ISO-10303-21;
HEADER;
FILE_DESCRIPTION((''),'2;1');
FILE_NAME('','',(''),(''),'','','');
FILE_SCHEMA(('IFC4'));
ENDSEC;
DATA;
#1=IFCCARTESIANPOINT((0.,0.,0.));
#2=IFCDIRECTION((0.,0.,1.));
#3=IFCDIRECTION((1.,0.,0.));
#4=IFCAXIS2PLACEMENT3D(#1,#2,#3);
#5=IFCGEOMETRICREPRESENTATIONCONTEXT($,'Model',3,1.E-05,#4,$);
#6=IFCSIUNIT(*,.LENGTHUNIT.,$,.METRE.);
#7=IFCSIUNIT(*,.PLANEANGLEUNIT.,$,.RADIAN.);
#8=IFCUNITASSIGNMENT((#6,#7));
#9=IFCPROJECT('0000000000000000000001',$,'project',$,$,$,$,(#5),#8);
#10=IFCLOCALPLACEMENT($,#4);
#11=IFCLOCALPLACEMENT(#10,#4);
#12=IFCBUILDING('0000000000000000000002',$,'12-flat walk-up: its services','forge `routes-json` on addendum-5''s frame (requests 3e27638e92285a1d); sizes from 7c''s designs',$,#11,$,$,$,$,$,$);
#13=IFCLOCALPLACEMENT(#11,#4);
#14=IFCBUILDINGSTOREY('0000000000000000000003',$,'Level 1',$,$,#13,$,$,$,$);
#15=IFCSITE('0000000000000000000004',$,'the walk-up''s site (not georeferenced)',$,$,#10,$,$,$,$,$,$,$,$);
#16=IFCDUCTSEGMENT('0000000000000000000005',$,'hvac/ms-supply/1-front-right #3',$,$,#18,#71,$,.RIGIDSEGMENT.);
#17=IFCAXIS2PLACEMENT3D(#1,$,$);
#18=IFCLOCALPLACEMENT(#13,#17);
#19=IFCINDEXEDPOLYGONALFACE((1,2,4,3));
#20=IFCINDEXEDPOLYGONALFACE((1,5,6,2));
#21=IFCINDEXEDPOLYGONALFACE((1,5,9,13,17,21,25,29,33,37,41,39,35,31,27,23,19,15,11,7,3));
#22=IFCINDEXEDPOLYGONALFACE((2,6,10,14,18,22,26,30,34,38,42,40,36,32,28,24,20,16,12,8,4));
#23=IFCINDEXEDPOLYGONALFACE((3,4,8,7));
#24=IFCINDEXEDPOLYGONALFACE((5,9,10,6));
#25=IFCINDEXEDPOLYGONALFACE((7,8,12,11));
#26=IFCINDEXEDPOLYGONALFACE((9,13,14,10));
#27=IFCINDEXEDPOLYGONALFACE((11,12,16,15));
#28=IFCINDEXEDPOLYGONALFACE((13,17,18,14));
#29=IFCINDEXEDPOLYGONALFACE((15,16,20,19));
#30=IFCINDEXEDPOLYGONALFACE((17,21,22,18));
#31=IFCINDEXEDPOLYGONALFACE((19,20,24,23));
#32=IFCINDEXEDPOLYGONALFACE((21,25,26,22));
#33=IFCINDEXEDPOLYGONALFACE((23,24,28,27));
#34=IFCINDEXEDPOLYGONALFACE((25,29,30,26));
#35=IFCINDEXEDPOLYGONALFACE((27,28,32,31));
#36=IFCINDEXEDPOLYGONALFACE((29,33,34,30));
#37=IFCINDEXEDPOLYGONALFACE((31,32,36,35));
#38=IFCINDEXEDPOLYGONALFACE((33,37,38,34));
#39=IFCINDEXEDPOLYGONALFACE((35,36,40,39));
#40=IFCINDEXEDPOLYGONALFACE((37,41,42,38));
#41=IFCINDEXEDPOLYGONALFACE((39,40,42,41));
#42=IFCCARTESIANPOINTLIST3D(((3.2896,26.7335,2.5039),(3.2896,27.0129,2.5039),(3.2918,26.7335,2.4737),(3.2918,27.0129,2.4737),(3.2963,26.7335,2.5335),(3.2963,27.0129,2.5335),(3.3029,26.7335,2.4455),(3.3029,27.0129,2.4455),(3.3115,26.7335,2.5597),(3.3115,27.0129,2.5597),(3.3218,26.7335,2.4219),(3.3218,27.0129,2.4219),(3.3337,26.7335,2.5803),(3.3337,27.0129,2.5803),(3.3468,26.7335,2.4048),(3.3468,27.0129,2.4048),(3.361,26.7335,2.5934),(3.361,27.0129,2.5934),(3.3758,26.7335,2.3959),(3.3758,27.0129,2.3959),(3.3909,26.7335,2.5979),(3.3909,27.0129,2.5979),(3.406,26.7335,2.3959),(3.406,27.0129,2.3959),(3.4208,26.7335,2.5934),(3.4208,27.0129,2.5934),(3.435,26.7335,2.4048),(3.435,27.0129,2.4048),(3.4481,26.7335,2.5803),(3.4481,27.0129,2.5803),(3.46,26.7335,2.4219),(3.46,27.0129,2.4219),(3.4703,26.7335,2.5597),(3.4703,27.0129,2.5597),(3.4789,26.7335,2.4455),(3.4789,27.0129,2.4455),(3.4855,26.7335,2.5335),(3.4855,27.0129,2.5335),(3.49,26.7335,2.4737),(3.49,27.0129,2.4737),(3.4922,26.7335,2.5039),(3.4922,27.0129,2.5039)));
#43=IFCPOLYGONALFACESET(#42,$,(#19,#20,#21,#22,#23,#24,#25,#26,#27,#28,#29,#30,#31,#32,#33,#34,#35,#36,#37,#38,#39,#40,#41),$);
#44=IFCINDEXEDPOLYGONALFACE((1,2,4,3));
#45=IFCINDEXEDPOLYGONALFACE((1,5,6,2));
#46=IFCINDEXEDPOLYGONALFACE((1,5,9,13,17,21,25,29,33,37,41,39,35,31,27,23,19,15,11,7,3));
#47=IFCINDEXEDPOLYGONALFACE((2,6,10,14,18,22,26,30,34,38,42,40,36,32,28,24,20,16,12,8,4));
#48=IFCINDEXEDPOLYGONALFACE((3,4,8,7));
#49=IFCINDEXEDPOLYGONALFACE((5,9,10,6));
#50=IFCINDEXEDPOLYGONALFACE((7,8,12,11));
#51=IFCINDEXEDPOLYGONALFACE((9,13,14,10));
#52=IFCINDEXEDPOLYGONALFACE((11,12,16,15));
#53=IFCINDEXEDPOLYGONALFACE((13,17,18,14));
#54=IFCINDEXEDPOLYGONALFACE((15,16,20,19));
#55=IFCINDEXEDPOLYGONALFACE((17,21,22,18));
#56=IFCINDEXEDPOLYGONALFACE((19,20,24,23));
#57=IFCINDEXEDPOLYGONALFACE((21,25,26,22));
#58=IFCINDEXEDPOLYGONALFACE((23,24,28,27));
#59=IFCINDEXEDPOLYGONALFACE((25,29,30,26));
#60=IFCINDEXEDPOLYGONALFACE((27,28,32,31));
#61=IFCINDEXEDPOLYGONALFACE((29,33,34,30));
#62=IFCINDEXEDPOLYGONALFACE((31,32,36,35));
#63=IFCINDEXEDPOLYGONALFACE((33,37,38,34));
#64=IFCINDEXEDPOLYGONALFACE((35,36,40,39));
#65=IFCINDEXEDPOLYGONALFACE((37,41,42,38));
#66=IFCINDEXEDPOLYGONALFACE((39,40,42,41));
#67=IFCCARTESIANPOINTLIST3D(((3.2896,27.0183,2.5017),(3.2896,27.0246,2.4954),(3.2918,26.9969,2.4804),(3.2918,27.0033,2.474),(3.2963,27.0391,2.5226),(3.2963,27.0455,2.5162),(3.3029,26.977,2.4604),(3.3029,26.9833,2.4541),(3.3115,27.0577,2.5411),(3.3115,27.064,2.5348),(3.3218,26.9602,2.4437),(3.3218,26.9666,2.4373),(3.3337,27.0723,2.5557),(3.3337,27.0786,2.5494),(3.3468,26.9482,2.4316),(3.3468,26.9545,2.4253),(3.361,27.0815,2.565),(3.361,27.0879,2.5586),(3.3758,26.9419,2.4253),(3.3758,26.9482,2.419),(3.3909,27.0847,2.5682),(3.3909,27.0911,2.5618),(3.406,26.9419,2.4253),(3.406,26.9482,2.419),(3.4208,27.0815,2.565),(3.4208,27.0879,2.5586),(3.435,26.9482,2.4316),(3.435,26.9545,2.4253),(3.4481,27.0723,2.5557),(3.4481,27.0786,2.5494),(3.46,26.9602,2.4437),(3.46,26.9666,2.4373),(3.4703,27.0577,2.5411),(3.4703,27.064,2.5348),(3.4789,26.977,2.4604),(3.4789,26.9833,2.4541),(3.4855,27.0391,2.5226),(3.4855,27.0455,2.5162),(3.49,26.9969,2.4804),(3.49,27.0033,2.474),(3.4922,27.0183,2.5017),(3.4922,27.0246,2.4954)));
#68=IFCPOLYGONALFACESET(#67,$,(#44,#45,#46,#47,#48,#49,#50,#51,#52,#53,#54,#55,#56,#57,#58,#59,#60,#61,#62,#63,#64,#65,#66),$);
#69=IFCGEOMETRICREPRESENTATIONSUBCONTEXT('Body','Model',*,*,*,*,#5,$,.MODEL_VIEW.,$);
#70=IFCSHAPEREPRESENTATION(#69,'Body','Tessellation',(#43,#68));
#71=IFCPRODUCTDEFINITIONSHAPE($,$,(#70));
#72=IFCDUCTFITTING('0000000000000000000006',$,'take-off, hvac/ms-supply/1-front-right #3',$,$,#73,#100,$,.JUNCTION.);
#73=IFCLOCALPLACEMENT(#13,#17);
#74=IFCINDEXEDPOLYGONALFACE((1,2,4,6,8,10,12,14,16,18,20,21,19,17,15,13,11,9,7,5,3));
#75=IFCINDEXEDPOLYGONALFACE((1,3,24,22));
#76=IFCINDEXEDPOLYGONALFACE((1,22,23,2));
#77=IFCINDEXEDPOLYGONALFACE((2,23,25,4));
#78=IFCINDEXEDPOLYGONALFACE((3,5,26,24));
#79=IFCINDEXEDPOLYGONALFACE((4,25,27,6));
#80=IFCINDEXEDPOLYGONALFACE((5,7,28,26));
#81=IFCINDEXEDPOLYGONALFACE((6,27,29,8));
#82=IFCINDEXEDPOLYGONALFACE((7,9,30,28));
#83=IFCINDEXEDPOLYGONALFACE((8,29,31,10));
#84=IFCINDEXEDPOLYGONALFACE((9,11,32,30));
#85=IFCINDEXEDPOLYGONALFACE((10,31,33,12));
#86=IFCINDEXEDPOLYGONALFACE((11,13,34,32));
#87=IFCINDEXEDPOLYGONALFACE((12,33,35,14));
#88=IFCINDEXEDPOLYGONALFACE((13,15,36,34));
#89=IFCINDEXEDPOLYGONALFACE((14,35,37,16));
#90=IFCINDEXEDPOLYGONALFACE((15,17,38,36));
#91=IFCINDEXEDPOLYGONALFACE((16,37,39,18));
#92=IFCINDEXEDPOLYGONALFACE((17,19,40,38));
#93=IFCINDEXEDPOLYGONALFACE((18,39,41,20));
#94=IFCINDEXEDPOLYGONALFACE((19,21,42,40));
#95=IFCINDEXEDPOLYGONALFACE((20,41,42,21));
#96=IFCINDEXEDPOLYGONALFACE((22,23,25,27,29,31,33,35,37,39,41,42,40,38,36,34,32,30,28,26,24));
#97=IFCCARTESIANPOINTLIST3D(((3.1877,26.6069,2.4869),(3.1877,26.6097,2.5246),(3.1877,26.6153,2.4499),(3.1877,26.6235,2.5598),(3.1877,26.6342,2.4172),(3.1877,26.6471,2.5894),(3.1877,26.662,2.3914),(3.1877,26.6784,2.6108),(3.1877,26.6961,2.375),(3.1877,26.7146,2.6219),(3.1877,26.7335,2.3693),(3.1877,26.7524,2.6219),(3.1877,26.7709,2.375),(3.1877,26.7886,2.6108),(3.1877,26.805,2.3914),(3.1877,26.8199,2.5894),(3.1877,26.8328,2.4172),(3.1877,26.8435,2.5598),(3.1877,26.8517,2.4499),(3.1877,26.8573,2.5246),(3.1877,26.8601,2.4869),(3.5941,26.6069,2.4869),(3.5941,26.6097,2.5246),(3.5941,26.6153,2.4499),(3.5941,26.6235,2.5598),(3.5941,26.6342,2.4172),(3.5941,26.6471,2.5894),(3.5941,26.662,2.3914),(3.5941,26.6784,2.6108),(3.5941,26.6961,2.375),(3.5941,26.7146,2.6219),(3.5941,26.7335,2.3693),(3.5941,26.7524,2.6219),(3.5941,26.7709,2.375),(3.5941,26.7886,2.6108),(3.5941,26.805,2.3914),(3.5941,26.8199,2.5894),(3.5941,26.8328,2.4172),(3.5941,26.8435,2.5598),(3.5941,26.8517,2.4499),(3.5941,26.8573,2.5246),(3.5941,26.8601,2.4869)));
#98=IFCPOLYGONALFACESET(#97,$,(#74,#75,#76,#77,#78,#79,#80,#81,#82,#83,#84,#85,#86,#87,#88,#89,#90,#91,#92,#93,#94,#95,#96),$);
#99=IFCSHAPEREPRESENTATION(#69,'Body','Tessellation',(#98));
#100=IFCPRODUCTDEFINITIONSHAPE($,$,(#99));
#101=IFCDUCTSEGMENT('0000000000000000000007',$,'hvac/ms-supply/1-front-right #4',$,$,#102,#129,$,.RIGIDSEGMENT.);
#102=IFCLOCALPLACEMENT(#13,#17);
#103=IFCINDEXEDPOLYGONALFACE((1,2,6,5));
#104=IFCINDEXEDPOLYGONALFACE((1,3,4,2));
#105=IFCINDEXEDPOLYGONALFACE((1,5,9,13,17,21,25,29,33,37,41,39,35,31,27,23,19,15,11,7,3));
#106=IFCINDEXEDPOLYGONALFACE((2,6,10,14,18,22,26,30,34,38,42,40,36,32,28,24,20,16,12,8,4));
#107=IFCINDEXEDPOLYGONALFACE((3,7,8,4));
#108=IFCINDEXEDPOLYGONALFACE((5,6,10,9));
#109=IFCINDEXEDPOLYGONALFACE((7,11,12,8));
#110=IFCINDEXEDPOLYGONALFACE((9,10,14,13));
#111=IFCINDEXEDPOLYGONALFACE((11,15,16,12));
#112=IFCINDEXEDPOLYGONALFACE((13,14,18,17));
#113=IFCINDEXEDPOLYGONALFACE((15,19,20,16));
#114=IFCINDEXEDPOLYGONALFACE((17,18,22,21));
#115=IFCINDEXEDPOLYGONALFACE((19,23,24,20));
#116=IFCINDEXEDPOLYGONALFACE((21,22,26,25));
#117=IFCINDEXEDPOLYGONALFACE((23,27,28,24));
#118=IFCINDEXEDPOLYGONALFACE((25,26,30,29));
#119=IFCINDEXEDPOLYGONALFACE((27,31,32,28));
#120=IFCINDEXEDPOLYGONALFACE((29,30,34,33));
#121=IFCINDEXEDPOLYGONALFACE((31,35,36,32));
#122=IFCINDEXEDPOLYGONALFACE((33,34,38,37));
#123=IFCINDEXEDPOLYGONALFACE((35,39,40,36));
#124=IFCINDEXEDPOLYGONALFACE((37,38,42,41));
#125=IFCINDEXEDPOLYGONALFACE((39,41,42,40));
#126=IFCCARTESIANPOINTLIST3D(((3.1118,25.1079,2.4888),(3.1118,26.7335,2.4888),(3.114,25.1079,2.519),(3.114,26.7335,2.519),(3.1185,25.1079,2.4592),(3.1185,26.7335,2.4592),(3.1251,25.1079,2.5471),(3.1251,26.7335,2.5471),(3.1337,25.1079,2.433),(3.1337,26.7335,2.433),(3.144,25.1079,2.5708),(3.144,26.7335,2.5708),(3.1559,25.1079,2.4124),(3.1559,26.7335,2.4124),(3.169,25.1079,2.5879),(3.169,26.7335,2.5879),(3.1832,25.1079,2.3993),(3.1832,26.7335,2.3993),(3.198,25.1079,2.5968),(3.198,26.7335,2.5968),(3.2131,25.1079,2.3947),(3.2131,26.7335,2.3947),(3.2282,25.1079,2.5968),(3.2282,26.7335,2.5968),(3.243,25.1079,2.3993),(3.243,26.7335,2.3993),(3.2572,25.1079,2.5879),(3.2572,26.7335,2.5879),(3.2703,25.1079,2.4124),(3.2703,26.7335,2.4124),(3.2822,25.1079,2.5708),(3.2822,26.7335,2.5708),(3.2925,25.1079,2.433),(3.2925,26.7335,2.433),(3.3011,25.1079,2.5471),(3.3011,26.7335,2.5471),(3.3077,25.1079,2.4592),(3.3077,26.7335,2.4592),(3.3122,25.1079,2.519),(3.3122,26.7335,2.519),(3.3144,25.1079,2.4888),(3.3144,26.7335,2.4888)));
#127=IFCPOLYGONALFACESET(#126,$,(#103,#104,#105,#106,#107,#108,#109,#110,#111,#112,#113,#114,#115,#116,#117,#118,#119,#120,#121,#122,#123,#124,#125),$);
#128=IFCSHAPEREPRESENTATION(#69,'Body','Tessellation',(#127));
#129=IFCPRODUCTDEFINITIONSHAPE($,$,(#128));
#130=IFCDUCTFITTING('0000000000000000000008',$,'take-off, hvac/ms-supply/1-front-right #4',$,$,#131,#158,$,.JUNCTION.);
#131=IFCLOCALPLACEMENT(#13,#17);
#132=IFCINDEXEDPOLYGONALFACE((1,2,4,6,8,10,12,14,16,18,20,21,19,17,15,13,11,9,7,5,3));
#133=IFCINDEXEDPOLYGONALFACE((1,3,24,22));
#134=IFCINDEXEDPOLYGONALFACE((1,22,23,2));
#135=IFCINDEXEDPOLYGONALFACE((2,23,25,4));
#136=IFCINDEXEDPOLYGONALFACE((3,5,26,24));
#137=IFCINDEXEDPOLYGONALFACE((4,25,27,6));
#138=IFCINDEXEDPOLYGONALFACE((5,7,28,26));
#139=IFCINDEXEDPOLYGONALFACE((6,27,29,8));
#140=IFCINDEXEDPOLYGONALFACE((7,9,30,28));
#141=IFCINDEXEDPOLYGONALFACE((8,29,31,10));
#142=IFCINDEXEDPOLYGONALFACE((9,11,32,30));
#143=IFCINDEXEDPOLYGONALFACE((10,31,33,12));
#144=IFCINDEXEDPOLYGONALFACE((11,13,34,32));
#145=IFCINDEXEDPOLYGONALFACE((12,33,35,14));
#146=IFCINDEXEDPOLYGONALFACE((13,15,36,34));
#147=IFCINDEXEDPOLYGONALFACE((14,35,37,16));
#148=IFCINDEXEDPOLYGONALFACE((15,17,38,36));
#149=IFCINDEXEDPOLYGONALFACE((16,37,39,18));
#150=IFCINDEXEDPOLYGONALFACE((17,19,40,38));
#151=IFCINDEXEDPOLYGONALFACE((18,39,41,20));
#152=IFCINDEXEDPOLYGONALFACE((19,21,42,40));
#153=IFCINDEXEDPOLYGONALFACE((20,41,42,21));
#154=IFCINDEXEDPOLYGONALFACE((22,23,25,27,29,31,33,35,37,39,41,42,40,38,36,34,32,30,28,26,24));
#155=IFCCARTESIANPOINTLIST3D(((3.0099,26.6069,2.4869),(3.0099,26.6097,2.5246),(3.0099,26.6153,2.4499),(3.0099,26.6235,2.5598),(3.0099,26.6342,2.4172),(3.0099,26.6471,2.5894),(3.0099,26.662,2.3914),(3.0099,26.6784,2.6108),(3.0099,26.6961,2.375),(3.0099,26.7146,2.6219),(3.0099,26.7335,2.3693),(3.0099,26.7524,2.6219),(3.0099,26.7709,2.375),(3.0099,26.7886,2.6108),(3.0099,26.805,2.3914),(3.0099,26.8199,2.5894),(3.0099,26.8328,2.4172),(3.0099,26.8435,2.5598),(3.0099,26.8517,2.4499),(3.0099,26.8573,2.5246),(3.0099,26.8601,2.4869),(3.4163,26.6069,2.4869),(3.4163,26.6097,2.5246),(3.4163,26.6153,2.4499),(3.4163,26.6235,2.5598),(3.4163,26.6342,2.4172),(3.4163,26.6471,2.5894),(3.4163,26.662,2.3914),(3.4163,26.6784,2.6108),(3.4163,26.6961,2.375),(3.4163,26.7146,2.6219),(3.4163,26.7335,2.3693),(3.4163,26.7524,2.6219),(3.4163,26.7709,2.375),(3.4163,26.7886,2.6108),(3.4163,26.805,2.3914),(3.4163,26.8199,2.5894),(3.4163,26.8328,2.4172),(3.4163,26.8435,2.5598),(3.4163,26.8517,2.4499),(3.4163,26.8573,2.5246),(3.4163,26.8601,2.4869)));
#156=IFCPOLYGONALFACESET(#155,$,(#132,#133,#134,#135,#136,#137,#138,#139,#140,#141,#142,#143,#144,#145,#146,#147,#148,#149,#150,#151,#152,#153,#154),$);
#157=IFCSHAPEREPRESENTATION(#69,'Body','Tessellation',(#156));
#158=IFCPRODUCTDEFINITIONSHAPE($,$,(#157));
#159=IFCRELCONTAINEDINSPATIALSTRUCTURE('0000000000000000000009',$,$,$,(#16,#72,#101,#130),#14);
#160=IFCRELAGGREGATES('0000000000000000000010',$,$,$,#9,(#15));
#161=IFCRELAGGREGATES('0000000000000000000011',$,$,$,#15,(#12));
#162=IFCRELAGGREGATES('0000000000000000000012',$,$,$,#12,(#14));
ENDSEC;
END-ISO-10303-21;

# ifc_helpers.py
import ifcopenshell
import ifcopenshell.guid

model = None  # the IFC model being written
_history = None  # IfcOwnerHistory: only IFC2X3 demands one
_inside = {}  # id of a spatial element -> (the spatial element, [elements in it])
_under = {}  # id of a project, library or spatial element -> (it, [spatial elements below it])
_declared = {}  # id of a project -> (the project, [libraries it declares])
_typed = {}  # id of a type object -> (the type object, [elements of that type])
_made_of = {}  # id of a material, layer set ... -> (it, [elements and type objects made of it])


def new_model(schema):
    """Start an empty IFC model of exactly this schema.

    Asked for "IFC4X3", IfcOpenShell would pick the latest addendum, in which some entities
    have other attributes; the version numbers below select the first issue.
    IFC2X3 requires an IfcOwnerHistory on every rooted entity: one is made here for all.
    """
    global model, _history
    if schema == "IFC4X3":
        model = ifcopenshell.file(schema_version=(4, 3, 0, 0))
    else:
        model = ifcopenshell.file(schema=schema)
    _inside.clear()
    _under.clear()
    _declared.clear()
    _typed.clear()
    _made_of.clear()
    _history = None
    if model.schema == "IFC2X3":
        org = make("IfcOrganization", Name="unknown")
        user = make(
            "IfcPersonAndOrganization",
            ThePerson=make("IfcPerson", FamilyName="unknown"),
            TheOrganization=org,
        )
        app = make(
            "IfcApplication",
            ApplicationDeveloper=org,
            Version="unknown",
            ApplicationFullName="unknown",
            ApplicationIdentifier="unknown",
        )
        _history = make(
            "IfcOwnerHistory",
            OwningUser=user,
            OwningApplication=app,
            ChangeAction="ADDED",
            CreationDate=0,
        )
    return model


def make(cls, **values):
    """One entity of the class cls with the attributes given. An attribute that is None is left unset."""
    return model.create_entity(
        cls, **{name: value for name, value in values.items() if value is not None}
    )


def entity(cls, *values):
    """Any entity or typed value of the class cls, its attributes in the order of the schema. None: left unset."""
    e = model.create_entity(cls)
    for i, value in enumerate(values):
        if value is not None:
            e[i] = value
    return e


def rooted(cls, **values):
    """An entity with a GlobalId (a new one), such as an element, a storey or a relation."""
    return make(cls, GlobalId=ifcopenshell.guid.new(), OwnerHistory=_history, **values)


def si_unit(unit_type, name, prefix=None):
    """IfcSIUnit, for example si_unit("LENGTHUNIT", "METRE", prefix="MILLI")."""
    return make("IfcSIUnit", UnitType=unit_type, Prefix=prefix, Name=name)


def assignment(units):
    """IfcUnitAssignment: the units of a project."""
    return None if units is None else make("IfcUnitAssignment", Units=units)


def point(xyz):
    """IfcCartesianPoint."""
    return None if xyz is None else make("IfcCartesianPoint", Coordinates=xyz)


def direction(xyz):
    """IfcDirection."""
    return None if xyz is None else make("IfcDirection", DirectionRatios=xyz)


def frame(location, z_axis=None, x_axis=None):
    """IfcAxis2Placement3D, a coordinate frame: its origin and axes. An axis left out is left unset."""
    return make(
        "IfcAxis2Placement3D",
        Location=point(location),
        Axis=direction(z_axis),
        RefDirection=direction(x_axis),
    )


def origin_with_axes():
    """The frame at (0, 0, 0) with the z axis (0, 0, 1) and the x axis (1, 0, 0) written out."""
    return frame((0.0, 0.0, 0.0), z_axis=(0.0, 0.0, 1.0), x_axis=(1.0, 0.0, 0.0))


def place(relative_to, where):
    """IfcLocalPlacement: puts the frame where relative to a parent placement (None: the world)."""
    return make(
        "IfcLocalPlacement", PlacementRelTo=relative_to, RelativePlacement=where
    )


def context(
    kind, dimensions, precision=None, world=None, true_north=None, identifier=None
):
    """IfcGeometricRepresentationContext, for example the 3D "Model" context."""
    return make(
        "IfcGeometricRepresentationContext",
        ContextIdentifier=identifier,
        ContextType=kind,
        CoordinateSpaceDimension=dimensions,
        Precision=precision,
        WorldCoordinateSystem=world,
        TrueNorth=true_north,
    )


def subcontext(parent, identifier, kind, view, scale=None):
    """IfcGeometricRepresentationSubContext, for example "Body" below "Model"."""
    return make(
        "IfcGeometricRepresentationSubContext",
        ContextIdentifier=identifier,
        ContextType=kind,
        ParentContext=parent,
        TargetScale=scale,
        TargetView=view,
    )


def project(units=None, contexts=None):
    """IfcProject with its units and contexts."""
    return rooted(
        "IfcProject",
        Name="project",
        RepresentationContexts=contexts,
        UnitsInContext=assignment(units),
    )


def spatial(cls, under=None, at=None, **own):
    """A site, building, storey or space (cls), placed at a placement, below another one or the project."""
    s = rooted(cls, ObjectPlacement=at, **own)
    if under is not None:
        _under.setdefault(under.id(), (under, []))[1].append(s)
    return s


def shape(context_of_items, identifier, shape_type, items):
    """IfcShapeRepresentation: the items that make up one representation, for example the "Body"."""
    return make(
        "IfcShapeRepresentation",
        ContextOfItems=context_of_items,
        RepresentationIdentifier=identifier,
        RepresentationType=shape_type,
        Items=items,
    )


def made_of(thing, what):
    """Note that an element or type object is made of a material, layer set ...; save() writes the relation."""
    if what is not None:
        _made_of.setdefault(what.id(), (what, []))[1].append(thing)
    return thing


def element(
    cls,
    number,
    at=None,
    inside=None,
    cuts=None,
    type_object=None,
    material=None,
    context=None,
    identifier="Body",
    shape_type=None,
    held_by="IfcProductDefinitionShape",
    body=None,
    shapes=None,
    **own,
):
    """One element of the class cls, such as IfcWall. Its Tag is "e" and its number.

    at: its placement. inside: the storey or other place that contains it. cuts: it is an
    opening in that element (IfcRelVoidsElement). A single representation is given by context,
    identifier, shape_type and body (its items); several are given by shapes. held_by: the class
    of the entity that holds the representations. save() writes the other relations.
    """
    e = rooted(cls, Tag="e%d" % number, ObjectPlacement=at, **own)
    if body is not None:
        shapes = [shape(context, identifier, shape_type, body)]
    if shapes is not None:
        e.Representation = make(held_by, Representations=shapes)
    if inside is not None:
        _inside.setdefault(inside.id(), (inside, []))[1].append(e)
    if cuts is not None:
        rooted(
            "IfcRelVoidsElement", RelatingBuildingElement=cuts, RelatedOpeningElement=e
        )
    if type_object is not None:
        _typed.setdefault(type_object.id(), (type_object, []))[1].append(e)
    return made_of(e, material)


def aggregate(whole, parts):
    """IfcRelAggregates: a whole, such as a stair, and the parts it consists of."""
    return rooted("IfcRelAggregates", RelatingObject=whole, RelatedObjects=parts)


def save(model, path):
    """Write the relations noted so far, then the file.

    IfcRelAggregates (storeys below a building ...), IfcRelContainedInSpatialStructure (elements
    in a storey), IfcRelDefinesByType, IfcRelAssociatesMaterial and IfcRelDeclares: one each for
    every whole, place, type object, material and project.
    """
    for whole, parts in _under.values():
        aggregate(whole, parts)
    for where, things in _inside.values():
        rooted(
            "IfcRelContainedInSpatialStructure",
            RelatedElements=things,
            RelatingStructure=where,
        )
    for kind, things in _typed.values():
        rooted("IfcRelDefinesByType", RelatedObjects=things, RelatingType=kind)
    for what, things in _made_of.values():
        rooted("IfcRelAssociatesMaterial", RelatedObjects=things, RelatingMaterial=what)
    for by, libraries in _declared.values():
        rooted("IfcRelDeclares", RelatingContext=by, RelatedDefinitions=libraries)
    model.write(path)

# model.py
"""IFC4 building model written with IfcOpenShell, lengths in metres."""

from ifc_helpers import new_model, entity, si_unit, frame, origin_with_axes, place, context, subcontext, project, spatial, element, save


model = new_model("IFC4")

# Units and contexts
model_context = context("Model", 3, precision=1e-05, world=origin_with_axes())
body_context = subcontext(model_context, "Body", "Model", "MODEL_VIEW")
ifc_project = project(units=[si_unit("LENGTHUNIT", "METRE"), si_unit("PLANEANGLEUNIT", "RADIAN")], contexts=[model_context])

# Site, building, storey
site_placement = place(None, origin_with_axes())
site = spatial("IfcSite", under=ifc_project, at=site_placement, Name="the walk-up's site (not georeferenced)")
building_placement = place(site_placement, origin_with_axes())
building = spatial("IfcBuilding", under=site, at=building_placement, Name="12-flat walk-up: its services", Description="forge `routes-json` on addendum-5's frame (requests 3e27638e92285a1d); sizes from 7c's designs")
storey_placement = place(building_placement, origin_with_axes())
storey = spatial("IfcBuildingStorey", under=building, at=storey_placement, Name="Level 1")

# Duct segment
duct_segment_1_placement = place(storey_placement, frame((3.3909, 26.7335, 2.4963), z_axis=(0.0, 0.0, 1.0), x_axis=(1.0, 0.0, 0.0)))
element("IfcDuctSegment", 1, at=duct_segment_1_placement, inside=storey, Name="hvac/ms-supply/1-front-right #3", PredefinedType="RIGIDSEGMENT", context=body_context, shape_type="AdvancedSweptSolid", body=[
    entity("IfcSweptDiskSolid", entity("IfcPolyline", [entity("IfcCartesianPoint", [0.0, 0.0, 0.0]), entity("IfcCartesianPoint", [0.0, 0.2794, 0.0])]), 0.1016),
    entity("IfcSweptDiskSolid", entity("IfcPolyline", [entity("IfcCartesianPoint", [0.0, 0.2794, 0.0]), entity("IfcCartesianPoint", [0.0, 0.2858, -0.0063])]), 0.1016),
])

# Duct fitting
duct_fitting_1_placement = place(storey_placement, frame((3.5941, 26.7335, 2.4963), z_axis=(0.0, 0.0, 1.0), x_axis=(1.0, 0.0, 0.0)))
element("IfcDuctFitting", 2, at=duct_fitting_1_placement, inside=storey, Name="take-off, hvac/ms-supply/1-front-right #3", PredefinedType="JUNCTION", context=body_context, shape_type="AdvancedSweptSolid", body=[
    entity("IfcSweptDiskSolid", entity("IfcPolyline", [entity("IfcCartesianPoint", [0.0, 0.0, 0.0]), entity("IfcCartesianPoint", [-0.4064, 0.0, 0.0])]), 0.127),
])

# Duct segment
duct_segment_2_placement = place(storey_placement, frame((3.2131, 26.7335, 2.4963), z_axis=(0.0, 0.0, 1.0), x_axis=(1.0, 0.0, 0.0)))
element("IfcDuctSegment", 3, at=duct_segment_2_placement, inside=storey, Name="hvac/ms-supply/1-front-right #4", PredefinedType="RIGIDSEGMENT", context=body_context, shape_type="AdvancedSweptSolid", body=[
    entity("IfcSweptDiskSolid", entity("IfcPolyline", [entity("IfcCartesianPoint", [0.0, 0.0, 0.0]), entity("IfcCartesianPoint", [0.0, -1.6256, 0.0])]), 0.1016),
])

# Duct fitting
duct_fitting_2_placement = place(storey_placement, frame((3.4163, 26.7335, 2.4963), z_axis=(0.0, 0.0, 1.0), x_axis=(1.0, 0.0, 0.0)))
element("IfcDuctFitting", 4, at=duct_fitting_2_placement, inside=storey, Name="take-off, hvac/ms-supply/1-front-right #4", PredefinedType="JUNCTION", context=body_context, shape_type="AdvancedSweptSolid", body=[
    entity("IfcSweptDiskSolid", entity("IfcPolyline", [entity("IfcCartesianPoint", [0.0, 0.0, 0.0]), entity("IfcCartesianPoint", [-0.4064, 0.0, 0.0])]), 0.127),
])

save(model, "model.ifc")
